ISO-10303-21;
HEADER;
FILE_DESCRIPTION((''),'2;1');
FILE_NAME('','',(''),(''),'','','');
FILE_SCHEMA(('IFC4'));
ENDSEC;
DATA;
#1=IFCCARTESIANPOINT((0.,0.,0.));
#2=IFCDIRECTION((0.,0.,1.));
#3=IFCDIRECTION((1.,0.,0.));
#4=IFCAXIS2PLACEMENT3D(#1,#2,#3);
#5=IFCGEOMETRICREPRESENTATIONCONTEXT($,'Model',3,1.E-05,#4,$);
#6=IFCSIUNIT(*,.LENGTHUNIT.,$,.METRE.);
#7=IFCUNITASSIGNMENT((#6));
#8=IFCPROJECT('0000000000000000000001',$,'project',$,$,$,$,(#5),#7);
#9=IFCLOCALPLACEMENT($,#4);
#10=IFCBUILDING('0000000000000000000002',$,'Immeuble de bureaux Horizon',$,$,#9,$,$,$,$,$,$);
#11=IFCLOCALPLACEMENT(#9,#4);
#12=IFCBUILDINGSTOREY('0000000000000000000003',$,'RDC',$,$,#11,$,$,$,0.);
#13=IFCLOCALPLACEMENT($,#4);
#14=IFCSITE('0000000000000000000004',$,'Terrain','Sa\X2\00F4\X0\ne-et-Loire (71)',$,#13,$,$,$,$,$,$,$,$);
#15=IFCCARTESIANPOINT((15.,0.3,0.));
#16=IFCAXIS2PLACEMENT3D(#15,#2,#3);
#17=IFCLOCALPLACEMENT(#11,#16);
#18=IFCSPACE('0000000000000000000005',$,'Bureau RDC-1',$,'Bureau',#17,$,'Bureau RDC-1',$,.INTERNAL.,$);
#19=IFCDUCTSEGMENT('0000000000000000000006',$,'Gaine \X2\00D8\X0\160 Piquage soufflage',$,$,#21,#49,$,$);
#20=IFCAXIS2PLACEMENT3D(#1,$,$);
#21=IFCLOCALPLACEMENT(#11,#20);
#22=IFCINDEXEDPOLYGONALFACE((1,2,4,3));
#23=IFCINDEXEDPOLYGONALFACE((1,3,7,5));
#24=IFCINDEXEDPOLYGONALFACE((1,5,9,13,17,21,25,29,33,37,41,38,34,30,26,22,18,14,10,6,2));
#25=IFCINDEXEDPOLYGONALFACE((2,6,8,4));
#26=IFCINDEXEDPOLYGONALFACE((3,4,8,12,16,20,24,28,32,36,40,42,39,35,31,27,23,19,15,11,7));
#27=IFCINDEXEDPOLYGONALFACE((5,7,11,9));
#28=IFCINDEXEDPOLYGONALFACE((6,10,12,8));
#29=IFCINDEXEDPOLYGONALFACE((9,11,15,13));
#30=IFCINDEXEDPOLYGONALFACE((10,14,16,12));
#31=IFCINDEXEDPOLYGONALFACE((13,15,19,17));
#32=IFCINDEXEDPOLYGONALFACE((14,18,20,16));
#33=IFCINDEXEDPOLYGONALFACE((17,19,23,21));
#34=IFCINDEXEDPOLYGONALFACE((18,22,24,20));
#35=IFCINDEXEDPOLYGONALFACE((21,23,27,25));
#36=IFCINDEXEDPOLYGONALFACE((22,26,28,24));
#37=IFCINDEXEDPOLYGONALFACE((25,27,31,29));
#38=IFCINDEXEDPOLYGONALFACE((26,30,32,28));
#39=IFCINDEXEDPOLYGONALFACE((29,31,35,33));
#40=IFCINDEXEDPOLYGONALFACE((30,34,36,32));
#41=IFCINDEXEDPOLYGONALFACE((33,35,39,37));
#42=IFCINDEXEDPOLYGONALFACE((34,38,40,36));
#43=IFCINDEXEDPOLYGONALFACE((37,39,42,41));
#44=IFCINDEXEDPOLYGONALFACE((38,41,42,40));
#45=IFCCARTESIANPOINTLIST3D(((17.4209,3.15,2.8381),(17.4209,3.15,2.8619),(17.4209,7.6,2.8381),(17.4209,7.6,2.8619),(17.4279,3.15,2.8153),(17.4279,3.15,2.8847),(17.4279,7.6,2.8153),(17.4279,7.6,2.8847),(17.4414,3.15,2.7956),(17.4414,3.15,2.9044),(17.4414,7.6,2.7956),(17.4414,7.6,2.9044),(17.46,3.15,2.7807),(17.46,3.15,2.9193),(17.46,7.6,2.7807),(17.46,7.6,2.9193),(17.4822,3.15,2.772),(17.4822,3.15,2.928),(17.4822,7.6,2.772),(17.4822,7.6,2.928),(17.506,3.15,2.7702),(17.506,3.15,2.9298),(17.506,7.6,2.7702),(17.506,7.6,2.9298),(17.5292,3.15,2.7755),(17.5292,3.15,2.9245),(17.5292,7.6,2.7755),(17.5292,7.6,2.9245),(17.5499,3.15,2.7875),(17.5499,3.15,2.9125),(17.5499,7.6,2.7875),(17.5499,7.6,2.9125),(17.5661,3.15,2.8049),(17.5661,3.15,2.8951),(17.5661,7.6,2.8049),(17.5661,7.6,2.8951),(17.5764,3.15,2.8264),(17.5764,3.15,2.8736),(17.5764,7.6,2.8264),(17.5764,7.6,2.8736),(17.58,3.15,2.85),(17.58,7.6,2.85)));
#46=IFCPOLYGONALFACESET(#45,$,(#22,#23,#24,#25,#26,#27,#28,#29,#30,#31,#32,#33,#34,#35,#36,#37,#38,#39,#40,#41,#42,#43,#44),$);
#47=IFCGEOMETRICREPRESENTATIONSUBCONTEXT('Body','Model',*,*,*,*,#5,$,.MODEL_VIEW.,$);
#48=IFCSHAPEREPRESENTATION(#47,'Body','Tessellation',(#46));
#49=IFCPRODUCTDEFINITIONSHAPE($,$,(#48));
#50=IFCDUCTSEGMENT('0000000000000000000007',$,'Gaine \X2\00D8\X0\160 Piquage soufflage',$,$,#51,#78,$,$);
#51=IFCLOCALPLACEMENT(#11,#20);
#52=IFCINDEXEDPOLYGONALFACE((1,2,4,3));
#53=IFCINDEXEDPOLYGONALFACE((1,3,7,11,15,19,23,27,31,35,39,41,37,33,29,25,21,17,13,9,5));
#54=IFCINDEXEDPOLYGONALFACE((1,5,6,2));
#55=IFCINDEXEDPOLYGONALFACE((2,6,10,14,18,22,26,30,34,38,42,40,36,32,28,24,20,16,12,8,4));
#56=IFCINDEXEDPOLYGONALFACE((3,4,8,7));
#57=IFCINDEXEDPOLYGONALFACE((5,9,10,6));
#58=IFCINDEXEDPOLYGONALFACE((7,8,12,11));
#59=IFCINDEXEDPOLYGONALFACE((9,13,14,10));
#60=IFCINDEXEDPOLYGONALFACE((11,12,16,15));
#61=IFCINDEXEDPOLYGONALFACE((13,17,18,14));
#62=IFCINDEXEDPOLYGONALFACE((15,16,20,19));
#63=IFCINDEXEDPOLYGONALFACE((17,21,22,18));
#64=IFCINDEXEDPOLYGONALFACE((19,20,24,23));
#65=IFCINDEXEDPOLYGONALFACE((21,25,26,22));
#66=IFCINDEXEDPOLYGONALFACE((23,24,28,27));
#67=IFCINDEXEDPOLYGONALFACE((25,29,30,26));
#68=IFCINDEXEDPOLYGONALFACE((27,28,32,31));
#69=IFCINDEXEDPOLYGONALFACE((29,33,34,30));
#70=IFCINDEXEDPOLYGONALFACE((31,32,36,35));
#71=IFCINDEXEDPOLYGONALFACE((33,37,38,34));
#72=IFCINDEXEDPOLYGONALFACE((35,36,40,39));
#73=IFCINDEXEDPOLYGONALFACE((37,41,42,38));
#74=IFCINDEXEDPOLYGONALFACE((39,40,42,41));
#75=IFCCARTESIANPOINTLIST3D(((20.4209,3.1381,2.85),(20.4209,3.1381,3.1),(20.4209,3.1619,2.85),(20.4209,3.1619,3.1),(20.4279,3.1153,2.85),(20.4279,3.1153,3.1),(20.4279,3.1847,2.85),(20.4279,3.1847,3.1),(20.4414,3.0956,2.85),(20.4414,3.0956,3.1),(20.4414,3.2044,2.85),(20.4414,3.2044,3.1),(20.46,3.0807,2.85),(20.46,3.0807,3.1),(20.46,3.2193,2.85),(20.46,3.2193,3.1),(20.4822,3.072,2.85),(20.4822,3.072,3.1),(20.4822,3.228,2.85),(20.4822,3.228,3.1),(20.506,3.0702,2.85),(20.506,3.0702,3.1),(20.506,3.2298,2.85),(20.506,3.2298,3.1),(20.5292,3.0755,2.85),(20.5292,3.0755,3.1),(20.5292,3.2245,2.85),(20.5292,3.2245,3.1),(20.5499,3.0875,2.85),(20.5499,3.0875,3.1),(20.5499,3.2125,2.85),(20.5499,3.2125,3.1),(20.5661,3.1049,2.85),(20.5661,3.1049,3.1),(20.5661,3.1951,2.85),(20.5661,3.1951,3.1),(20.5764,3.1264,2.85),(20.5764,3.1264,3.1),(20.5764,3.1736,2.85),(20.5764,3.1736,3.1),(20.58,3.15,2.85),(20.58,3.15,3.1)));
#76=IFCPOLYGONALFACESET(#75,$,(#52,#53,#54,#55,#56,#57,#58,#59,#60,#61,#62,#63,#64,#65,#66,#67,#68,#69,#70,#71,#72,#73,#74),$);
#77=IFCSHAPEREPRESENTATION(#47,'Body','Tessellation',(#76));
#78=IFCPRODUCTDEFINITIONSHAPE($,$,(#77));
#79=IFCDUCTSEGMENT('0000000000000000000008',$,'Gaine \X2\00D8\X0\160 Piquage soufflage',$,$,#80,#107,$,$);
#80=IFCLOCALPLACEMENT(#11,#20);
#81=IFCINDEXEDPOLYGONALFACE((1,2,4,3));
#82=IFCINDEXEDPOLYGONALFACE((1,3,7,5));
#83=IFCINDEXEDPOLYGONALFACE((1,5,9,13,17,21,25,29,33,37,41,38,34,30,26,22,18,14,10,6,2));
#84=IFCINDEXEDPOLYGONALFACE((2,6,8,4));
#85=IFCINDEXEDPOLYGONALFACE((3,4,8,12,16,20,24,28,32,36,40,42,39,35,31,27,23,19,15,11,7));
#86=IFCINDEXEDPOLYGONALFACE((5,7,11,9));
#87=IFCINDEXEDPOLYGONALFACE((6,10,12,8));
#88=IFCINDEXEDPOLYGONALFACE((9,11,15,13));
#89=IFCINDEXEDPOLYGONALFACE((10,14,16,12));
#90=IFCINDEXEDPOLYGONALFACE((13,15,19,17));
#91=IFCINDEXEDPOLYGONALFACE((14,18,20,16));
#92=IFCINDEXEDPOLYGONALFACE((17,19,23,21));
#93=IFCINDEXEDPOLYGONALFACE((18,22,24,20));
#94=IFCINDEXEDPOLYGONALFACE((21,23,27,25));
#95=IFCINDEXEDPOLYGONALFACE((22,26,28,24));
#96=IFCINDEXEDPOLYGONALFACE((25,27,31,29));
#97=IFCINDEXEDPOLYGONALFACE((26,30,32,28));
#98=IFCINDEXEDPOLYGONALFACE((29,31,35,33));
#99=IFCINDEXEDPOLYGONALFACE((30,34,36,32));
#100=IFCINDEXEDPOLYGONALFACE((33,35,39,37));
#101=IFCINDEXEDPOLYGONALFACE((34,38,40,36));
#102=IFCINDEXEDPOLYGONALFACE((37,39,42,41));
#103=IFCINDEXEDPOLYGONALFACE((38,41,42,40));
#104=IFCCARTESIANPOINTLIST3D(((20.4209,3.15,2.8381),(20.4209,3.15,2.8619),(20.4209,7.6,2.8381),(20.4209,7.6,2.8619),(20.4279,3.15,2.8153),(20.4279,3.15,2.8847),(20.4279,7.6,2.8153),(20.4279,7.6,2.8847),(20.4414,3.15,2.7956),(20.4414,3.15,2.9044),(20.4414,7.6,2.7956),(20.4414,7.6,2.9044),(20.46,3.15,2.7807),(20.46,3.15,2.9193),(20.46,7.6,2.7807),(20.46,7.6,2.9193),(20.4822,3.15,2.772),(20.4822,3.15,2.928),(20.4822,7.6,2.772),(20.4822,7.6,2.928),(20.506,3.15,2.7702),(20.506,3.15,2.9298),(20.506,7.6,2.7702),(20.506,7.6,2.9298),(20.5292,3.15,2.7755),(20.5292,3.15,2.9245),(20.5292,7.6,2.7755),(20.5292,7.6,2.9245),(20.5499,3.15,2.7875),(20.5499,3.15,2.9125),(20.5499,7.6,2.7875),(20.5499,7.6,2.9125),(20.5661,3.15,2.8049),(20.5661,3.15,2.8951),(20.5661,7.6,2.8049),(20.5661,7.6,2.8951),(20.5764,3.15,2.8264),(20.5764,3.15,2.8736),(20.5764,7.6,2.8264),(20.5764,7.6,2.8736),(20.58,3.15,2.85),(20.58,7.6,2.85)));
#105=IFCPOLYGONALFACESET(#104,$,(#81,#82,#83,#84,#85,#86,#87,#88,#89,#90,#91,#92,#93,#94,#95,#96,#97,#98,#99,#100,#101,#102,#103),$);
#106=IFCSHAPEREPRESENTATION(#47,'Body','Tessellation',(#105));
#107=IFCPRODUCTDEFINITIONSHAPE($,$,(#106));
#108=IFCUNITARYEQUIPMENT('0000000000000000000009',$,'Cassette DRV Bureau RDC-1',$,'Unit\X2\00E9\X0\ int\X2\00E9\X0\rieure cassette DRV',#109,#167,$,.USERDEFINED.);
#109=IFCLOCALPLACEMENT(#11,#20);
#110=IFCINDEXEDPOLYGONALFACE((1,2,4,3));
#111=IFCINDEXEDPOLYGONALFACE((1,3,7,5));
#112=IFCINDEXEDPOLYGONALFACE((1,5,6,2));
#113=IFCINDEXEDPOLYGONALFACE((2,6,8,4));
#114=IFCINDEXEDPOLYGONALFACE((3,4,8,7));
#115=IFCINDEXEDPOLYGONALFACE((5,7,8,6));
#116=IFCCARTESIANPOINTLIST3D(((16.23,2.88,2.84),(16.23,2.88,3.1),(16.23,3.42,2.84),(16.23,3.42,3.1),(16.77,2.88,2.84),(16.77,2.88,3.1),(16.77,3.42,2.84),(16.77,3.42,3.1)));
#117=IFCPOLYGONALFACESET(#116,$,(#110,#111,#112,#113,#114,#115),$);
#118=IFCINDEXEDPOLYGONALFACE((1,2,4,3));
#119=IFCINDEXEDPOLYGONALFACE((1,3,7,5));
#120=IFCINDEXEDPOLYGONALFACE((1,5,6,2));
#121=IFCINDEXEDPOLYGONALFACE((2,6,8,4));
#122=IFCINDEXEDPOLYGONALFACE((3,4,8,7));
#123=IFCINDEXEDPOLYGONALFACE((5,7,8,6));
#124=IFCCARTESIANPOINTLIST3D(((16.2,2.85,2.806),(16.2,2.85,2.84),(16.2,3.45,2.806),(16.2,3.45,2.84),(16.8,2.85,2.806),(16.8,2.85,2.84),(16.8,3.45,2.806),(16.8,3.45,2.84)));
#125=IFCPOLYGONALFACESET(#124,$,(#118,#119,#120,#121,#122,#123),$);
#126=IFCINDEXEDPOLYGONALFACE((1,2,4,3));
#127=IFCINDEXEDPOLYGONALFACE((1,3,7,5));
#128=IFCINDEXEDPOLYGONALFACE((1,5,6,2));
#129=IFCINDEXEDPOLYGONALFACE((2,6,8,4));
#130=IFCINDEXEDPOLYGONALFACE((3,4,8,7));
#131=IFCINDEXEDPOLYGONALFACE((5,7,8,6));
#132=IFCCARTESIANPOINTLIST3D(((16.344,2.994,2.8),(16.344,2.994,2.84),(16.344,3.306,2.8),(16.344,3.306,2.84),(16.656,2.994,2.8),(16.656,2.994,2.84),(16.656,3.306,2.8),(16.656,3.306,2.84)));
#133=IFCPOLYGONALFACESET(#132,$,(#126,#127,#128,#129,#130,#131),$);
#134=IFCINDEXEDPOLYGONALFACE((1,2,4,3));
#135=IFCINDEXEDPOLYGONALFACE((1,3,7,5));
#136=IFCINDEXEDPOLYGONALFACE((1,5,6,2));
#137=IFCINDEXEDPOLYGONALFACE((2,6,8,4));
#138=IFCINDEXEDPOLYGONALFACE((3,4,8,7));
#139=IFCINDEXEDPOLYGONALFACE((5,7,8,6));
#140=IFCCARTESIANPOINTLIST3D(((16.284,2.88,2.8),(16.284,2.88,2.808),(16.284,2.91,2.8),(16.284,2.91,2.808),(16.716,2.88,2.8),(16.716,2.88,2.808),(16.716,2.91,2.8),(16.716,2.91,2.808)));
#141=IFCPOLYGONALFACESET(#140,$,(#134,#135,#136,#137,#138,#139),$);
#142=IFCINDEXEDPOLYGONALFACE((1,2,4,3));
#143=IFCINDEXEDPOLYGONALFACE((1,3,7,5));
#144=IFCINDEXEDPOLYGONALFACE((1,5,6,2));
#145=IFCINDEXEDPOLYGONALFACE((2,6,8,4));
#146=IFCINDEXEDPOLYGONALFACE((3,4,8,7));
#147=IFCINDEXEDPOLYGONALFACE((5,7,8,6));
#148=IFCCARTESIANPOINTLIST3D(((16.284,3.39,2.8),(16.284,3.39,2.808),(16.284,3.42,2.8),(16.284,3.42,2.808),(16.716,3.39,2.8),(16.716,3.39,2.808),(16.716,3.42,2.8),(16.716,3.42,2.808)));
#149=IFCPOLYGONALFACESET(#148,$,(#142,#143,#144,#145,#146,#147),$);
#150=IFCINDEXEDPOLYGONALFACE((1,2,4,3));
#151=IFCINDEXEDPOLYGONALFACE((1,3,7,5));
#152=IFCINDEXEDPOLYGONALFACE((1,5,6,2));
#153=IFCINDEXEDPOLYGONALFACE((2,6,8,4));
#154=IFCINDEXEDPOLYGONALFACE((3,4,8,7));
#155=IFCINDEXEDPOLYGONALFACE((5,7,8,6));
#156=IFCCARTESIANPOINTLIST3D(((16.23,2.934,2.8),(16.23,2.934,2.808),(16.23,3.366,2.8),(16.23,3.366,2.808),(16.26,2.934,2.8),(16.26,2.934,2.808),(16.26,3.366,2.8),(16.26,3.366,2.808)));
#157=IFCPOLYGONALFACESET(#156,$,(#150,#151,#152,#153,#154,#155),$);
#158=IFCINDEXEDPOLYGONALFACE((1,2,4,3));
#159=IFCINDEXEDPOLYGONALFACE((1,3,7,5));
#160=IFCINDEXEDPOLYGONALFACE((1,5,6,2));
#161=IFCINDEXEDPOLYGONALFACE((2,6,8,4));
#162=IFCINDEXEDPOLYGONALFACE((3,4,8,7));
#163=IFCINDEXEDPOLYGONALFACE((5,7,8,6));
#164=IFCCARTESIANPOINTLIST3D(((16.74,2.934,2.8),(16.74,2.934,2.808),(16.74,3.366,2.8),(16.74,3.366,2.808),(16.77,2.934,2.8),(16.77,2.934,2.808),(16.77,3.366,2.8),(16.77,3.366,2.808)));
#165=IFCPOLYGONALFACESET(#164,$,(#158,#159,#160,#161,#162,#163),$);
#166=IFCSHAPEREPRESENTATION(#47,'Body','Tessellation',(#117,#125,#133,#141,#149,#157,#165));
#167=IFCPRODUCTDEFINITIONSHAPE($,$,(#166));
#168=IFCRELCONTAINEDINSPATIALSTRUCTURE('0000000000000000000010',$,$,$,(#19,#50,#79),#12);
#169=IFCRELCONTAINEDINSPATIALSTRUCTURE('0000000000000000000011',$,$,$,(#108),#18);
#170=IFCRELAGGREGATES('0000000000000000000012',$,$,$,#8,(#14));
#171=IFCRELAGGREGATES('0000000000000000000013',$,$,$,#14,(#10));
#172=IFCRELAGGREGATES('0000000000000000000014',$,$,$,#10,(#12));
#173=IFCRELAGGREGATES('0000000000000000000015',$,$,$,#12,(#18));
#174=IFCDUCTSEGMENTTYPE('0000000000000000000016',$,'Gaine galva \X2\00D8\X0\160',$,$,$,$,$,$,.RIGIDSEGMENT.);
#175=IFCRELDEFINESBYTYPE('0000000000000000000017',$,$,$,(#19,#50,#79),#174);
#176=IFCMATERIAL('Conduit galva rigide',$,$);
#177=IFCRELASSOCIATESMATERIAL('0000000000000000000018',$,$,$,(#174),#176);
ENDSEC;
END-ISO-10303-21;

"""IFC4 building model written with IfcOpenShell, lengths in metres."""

from ifc_helpers import new_model, si_unit, frame, frame_2d, origin_with_axes, place, context, subcontext, project, spatial, rectangle, circle, extrude, material, type_object, element, save


model = new_model("IFC4")

# Units and contexts
model_context = context("Model", 3, precision=1e-05, world=origin_with_axes())
body_context = subcontext(model_context, "Body", "Model", "MODEL_VIEW")
ifc_project = project(units=[si_unit("LENGTHUNIT", "METRE")], contexts=[model_context])

# Site, building, storey
site_placement = place(None, origin_with_axes())
site = spatial("IfcSite", under=ifc_project, at=site_placement, Name="Terrain", Description="Saône-et-Loire (71)")
building_placement = place(None, origin_with_axes())
building = spatial("IfcBuilding", under=site, at=building_placement, Name="Immeuble de bureaux Horizon")
storey_placement = place(building_placement, origin_with_axes())
storey = spatial("IfcBuildingStorey", under=building, at=storey_placement, Name="RDC", Elevation=0.0)

# Duct segments
ifc_material_1 = material(Name="Conduit galva rigide")
duct_segment_type = type_object("IfcDuctSegmentType", Name="Gaine galva Ø160", PredefinedType="RIGIDSEGMENT", material=ifc_material_1)
duct_segment_1_placement = place(storey_placement, frame((17.5, 3.15, 2.85), z_axis=(0.0, 1.0, 0.0), x_axis=(1.0, 0.0, 0.0)))
element("IfcDuctSegment", 1, at=duct_segment_1_placement, inside=storey, type_object=duct_segment_type, Name="Gaine Ø160 Piquage soufflage", context=body_context, shape_type="SweptSolid", body=[
    extrude(circle(Radius=0.08), origin_with_axes(), (0.0, 0.0, 1.0), 4.45),
])
duct_segment_2_placement = place(storey_placement, frame((20.5, 3.15, 3.1), z_axis=(0.0, 0.0, -1.0), x_axis=(1.0, 0.0, 0.0)))
element("IfcDuctSegment", 2, at=duct_segment_2_placement, inside=storey, type_object=duct_segment_type, Name="Gaine Ø160 Piquage soufflage", context=body_context, shape_type="SweptSolid", body=[
    extrude(circle(Radius=0.08), origin_with_axes(), (0.0, 0.0, 1.0), 0.25),
])
duct_segment_3_placement = place(storey_placement, frame((20.5, 3.15, 2.85), z_axis=(0.0, 1.0, 0.0), x_axis=(1.0, 0.0, 0.0)))
element("IfcDuctSegment", 3, at=duct_segment_3_placement, inside=storey, type_object=duct_segment_type, Name="Gaine Ø160 Piquage soufflage", context=body_context, shape_type="SweptSolid", body=[
    extrude(circle(Radius=0.08), origin_with_axes(), (0.0, 0.0, 1.0), 4.45),
])

# Shared definitions
space_1_placement = place(storey_placement, frame((15.0, 0.3, 0.0), z_axis=(0.0, 0.0, 1.0), x_axis=(1.0, 0.0, 0.0)))
space_1 = spatial("IfcSpace", under=storey, at=space_1_placement, Name="Bureau RDC-1", ObjectType="Bureau", LongName="Bureau RDC-1", PredefinedType="INTERNAL")

# Unitary equipment
unitary_equipment_1_placement = place(space_1_placement, frame((1.2, 2.55, 2.8), z_axis=(0.0, 0.0, 1.0), x_axis=(1.0, 0.0, 0.0)))
element("IfcUnitaryEquipment", 4, at=unitary_equipment_1_placement, inside=space_1, Name="Cassette DRV Bureau RDC-1", ObjectType="Unité intérieure cassette DRV", PredefinedType="USERDEFINED", context=body_context, shape_type="SweptSolid", body=[
    extrude(rectangle(XDim=0.54, YDim=0.54, at=frame_2d((0.27, 0.27))), frame((0.03, 0.03, 0.04), z_axis=(0.0, 0.0, 1.0), x_axis=(1.0, 0.0, 0.0)), (0.0, 0.0, 1.0), 0.26),
    extrude(rectangle(XDim=0.6, YDim=0.6, at=frame_2d((0.3, 0.3))), frame((0.0, 0.0, 0.006), z_axis=(0.0, 0.0, 1.0), x_axis=(1.0, 0.0, 0.0)), (0.0, 0.0, 1.0), 0.034),
    extrude(rectangle(XDim=0.312, YDim=0.312, at=frame_2d((0.156, 0.156))), frame((0.144, 0.144, 0.0), z_axis=(0.0, 0.0, 1.0), x_axis=(1.0, 0.0, 0.0)), (0.0, 0.0, 1.0), 0.04),
    extrude(rectangle(XDim=0.432, YDim=0.03, at=frame_2d((0.216, 0.015))), frame((0.084, 0.03, 0.0), z_axis=(0.0, 0.0, 1.0), x_axis=(1.0, 0.0, 0.0)), (0.0, 0.0, 1.0), 0.008),
    extrude(rectangle(XDim=0.432, YDim=0.03, at=frame_2d((0.216, 0.015))), frame((0.084, 0.54, 0.0), z_axis=(0.0, 0.0, 1.0), x_axis=(1.0, 0.0, 0.0)), (0.0, 0.0, 1.0), 0.008),
    extrude(rectangle(XDim=0.03, YDim=0.432, at=frame_2d((0.015, 0.216))), frame((0.03, 0.084, 0.0), z_axis=(0.0, 0.0, 1.0), x_axis=(1.0, 0.0, 0.0)), (0.0, 0.0, 1.0), 0.008),
    extrude(rectangle(XDim=0.03, YDim=0.432, at=frame_2d((0.015, 0.216))), frame((0.54, 0.084, 0.0), z_axis=(0.0, 0.0, 1.0), x_axis=(1.0, 0.0, 0.0)), (0.0, 0.0, 1.0), 0.008),
])

save(model, "model.ifc")
